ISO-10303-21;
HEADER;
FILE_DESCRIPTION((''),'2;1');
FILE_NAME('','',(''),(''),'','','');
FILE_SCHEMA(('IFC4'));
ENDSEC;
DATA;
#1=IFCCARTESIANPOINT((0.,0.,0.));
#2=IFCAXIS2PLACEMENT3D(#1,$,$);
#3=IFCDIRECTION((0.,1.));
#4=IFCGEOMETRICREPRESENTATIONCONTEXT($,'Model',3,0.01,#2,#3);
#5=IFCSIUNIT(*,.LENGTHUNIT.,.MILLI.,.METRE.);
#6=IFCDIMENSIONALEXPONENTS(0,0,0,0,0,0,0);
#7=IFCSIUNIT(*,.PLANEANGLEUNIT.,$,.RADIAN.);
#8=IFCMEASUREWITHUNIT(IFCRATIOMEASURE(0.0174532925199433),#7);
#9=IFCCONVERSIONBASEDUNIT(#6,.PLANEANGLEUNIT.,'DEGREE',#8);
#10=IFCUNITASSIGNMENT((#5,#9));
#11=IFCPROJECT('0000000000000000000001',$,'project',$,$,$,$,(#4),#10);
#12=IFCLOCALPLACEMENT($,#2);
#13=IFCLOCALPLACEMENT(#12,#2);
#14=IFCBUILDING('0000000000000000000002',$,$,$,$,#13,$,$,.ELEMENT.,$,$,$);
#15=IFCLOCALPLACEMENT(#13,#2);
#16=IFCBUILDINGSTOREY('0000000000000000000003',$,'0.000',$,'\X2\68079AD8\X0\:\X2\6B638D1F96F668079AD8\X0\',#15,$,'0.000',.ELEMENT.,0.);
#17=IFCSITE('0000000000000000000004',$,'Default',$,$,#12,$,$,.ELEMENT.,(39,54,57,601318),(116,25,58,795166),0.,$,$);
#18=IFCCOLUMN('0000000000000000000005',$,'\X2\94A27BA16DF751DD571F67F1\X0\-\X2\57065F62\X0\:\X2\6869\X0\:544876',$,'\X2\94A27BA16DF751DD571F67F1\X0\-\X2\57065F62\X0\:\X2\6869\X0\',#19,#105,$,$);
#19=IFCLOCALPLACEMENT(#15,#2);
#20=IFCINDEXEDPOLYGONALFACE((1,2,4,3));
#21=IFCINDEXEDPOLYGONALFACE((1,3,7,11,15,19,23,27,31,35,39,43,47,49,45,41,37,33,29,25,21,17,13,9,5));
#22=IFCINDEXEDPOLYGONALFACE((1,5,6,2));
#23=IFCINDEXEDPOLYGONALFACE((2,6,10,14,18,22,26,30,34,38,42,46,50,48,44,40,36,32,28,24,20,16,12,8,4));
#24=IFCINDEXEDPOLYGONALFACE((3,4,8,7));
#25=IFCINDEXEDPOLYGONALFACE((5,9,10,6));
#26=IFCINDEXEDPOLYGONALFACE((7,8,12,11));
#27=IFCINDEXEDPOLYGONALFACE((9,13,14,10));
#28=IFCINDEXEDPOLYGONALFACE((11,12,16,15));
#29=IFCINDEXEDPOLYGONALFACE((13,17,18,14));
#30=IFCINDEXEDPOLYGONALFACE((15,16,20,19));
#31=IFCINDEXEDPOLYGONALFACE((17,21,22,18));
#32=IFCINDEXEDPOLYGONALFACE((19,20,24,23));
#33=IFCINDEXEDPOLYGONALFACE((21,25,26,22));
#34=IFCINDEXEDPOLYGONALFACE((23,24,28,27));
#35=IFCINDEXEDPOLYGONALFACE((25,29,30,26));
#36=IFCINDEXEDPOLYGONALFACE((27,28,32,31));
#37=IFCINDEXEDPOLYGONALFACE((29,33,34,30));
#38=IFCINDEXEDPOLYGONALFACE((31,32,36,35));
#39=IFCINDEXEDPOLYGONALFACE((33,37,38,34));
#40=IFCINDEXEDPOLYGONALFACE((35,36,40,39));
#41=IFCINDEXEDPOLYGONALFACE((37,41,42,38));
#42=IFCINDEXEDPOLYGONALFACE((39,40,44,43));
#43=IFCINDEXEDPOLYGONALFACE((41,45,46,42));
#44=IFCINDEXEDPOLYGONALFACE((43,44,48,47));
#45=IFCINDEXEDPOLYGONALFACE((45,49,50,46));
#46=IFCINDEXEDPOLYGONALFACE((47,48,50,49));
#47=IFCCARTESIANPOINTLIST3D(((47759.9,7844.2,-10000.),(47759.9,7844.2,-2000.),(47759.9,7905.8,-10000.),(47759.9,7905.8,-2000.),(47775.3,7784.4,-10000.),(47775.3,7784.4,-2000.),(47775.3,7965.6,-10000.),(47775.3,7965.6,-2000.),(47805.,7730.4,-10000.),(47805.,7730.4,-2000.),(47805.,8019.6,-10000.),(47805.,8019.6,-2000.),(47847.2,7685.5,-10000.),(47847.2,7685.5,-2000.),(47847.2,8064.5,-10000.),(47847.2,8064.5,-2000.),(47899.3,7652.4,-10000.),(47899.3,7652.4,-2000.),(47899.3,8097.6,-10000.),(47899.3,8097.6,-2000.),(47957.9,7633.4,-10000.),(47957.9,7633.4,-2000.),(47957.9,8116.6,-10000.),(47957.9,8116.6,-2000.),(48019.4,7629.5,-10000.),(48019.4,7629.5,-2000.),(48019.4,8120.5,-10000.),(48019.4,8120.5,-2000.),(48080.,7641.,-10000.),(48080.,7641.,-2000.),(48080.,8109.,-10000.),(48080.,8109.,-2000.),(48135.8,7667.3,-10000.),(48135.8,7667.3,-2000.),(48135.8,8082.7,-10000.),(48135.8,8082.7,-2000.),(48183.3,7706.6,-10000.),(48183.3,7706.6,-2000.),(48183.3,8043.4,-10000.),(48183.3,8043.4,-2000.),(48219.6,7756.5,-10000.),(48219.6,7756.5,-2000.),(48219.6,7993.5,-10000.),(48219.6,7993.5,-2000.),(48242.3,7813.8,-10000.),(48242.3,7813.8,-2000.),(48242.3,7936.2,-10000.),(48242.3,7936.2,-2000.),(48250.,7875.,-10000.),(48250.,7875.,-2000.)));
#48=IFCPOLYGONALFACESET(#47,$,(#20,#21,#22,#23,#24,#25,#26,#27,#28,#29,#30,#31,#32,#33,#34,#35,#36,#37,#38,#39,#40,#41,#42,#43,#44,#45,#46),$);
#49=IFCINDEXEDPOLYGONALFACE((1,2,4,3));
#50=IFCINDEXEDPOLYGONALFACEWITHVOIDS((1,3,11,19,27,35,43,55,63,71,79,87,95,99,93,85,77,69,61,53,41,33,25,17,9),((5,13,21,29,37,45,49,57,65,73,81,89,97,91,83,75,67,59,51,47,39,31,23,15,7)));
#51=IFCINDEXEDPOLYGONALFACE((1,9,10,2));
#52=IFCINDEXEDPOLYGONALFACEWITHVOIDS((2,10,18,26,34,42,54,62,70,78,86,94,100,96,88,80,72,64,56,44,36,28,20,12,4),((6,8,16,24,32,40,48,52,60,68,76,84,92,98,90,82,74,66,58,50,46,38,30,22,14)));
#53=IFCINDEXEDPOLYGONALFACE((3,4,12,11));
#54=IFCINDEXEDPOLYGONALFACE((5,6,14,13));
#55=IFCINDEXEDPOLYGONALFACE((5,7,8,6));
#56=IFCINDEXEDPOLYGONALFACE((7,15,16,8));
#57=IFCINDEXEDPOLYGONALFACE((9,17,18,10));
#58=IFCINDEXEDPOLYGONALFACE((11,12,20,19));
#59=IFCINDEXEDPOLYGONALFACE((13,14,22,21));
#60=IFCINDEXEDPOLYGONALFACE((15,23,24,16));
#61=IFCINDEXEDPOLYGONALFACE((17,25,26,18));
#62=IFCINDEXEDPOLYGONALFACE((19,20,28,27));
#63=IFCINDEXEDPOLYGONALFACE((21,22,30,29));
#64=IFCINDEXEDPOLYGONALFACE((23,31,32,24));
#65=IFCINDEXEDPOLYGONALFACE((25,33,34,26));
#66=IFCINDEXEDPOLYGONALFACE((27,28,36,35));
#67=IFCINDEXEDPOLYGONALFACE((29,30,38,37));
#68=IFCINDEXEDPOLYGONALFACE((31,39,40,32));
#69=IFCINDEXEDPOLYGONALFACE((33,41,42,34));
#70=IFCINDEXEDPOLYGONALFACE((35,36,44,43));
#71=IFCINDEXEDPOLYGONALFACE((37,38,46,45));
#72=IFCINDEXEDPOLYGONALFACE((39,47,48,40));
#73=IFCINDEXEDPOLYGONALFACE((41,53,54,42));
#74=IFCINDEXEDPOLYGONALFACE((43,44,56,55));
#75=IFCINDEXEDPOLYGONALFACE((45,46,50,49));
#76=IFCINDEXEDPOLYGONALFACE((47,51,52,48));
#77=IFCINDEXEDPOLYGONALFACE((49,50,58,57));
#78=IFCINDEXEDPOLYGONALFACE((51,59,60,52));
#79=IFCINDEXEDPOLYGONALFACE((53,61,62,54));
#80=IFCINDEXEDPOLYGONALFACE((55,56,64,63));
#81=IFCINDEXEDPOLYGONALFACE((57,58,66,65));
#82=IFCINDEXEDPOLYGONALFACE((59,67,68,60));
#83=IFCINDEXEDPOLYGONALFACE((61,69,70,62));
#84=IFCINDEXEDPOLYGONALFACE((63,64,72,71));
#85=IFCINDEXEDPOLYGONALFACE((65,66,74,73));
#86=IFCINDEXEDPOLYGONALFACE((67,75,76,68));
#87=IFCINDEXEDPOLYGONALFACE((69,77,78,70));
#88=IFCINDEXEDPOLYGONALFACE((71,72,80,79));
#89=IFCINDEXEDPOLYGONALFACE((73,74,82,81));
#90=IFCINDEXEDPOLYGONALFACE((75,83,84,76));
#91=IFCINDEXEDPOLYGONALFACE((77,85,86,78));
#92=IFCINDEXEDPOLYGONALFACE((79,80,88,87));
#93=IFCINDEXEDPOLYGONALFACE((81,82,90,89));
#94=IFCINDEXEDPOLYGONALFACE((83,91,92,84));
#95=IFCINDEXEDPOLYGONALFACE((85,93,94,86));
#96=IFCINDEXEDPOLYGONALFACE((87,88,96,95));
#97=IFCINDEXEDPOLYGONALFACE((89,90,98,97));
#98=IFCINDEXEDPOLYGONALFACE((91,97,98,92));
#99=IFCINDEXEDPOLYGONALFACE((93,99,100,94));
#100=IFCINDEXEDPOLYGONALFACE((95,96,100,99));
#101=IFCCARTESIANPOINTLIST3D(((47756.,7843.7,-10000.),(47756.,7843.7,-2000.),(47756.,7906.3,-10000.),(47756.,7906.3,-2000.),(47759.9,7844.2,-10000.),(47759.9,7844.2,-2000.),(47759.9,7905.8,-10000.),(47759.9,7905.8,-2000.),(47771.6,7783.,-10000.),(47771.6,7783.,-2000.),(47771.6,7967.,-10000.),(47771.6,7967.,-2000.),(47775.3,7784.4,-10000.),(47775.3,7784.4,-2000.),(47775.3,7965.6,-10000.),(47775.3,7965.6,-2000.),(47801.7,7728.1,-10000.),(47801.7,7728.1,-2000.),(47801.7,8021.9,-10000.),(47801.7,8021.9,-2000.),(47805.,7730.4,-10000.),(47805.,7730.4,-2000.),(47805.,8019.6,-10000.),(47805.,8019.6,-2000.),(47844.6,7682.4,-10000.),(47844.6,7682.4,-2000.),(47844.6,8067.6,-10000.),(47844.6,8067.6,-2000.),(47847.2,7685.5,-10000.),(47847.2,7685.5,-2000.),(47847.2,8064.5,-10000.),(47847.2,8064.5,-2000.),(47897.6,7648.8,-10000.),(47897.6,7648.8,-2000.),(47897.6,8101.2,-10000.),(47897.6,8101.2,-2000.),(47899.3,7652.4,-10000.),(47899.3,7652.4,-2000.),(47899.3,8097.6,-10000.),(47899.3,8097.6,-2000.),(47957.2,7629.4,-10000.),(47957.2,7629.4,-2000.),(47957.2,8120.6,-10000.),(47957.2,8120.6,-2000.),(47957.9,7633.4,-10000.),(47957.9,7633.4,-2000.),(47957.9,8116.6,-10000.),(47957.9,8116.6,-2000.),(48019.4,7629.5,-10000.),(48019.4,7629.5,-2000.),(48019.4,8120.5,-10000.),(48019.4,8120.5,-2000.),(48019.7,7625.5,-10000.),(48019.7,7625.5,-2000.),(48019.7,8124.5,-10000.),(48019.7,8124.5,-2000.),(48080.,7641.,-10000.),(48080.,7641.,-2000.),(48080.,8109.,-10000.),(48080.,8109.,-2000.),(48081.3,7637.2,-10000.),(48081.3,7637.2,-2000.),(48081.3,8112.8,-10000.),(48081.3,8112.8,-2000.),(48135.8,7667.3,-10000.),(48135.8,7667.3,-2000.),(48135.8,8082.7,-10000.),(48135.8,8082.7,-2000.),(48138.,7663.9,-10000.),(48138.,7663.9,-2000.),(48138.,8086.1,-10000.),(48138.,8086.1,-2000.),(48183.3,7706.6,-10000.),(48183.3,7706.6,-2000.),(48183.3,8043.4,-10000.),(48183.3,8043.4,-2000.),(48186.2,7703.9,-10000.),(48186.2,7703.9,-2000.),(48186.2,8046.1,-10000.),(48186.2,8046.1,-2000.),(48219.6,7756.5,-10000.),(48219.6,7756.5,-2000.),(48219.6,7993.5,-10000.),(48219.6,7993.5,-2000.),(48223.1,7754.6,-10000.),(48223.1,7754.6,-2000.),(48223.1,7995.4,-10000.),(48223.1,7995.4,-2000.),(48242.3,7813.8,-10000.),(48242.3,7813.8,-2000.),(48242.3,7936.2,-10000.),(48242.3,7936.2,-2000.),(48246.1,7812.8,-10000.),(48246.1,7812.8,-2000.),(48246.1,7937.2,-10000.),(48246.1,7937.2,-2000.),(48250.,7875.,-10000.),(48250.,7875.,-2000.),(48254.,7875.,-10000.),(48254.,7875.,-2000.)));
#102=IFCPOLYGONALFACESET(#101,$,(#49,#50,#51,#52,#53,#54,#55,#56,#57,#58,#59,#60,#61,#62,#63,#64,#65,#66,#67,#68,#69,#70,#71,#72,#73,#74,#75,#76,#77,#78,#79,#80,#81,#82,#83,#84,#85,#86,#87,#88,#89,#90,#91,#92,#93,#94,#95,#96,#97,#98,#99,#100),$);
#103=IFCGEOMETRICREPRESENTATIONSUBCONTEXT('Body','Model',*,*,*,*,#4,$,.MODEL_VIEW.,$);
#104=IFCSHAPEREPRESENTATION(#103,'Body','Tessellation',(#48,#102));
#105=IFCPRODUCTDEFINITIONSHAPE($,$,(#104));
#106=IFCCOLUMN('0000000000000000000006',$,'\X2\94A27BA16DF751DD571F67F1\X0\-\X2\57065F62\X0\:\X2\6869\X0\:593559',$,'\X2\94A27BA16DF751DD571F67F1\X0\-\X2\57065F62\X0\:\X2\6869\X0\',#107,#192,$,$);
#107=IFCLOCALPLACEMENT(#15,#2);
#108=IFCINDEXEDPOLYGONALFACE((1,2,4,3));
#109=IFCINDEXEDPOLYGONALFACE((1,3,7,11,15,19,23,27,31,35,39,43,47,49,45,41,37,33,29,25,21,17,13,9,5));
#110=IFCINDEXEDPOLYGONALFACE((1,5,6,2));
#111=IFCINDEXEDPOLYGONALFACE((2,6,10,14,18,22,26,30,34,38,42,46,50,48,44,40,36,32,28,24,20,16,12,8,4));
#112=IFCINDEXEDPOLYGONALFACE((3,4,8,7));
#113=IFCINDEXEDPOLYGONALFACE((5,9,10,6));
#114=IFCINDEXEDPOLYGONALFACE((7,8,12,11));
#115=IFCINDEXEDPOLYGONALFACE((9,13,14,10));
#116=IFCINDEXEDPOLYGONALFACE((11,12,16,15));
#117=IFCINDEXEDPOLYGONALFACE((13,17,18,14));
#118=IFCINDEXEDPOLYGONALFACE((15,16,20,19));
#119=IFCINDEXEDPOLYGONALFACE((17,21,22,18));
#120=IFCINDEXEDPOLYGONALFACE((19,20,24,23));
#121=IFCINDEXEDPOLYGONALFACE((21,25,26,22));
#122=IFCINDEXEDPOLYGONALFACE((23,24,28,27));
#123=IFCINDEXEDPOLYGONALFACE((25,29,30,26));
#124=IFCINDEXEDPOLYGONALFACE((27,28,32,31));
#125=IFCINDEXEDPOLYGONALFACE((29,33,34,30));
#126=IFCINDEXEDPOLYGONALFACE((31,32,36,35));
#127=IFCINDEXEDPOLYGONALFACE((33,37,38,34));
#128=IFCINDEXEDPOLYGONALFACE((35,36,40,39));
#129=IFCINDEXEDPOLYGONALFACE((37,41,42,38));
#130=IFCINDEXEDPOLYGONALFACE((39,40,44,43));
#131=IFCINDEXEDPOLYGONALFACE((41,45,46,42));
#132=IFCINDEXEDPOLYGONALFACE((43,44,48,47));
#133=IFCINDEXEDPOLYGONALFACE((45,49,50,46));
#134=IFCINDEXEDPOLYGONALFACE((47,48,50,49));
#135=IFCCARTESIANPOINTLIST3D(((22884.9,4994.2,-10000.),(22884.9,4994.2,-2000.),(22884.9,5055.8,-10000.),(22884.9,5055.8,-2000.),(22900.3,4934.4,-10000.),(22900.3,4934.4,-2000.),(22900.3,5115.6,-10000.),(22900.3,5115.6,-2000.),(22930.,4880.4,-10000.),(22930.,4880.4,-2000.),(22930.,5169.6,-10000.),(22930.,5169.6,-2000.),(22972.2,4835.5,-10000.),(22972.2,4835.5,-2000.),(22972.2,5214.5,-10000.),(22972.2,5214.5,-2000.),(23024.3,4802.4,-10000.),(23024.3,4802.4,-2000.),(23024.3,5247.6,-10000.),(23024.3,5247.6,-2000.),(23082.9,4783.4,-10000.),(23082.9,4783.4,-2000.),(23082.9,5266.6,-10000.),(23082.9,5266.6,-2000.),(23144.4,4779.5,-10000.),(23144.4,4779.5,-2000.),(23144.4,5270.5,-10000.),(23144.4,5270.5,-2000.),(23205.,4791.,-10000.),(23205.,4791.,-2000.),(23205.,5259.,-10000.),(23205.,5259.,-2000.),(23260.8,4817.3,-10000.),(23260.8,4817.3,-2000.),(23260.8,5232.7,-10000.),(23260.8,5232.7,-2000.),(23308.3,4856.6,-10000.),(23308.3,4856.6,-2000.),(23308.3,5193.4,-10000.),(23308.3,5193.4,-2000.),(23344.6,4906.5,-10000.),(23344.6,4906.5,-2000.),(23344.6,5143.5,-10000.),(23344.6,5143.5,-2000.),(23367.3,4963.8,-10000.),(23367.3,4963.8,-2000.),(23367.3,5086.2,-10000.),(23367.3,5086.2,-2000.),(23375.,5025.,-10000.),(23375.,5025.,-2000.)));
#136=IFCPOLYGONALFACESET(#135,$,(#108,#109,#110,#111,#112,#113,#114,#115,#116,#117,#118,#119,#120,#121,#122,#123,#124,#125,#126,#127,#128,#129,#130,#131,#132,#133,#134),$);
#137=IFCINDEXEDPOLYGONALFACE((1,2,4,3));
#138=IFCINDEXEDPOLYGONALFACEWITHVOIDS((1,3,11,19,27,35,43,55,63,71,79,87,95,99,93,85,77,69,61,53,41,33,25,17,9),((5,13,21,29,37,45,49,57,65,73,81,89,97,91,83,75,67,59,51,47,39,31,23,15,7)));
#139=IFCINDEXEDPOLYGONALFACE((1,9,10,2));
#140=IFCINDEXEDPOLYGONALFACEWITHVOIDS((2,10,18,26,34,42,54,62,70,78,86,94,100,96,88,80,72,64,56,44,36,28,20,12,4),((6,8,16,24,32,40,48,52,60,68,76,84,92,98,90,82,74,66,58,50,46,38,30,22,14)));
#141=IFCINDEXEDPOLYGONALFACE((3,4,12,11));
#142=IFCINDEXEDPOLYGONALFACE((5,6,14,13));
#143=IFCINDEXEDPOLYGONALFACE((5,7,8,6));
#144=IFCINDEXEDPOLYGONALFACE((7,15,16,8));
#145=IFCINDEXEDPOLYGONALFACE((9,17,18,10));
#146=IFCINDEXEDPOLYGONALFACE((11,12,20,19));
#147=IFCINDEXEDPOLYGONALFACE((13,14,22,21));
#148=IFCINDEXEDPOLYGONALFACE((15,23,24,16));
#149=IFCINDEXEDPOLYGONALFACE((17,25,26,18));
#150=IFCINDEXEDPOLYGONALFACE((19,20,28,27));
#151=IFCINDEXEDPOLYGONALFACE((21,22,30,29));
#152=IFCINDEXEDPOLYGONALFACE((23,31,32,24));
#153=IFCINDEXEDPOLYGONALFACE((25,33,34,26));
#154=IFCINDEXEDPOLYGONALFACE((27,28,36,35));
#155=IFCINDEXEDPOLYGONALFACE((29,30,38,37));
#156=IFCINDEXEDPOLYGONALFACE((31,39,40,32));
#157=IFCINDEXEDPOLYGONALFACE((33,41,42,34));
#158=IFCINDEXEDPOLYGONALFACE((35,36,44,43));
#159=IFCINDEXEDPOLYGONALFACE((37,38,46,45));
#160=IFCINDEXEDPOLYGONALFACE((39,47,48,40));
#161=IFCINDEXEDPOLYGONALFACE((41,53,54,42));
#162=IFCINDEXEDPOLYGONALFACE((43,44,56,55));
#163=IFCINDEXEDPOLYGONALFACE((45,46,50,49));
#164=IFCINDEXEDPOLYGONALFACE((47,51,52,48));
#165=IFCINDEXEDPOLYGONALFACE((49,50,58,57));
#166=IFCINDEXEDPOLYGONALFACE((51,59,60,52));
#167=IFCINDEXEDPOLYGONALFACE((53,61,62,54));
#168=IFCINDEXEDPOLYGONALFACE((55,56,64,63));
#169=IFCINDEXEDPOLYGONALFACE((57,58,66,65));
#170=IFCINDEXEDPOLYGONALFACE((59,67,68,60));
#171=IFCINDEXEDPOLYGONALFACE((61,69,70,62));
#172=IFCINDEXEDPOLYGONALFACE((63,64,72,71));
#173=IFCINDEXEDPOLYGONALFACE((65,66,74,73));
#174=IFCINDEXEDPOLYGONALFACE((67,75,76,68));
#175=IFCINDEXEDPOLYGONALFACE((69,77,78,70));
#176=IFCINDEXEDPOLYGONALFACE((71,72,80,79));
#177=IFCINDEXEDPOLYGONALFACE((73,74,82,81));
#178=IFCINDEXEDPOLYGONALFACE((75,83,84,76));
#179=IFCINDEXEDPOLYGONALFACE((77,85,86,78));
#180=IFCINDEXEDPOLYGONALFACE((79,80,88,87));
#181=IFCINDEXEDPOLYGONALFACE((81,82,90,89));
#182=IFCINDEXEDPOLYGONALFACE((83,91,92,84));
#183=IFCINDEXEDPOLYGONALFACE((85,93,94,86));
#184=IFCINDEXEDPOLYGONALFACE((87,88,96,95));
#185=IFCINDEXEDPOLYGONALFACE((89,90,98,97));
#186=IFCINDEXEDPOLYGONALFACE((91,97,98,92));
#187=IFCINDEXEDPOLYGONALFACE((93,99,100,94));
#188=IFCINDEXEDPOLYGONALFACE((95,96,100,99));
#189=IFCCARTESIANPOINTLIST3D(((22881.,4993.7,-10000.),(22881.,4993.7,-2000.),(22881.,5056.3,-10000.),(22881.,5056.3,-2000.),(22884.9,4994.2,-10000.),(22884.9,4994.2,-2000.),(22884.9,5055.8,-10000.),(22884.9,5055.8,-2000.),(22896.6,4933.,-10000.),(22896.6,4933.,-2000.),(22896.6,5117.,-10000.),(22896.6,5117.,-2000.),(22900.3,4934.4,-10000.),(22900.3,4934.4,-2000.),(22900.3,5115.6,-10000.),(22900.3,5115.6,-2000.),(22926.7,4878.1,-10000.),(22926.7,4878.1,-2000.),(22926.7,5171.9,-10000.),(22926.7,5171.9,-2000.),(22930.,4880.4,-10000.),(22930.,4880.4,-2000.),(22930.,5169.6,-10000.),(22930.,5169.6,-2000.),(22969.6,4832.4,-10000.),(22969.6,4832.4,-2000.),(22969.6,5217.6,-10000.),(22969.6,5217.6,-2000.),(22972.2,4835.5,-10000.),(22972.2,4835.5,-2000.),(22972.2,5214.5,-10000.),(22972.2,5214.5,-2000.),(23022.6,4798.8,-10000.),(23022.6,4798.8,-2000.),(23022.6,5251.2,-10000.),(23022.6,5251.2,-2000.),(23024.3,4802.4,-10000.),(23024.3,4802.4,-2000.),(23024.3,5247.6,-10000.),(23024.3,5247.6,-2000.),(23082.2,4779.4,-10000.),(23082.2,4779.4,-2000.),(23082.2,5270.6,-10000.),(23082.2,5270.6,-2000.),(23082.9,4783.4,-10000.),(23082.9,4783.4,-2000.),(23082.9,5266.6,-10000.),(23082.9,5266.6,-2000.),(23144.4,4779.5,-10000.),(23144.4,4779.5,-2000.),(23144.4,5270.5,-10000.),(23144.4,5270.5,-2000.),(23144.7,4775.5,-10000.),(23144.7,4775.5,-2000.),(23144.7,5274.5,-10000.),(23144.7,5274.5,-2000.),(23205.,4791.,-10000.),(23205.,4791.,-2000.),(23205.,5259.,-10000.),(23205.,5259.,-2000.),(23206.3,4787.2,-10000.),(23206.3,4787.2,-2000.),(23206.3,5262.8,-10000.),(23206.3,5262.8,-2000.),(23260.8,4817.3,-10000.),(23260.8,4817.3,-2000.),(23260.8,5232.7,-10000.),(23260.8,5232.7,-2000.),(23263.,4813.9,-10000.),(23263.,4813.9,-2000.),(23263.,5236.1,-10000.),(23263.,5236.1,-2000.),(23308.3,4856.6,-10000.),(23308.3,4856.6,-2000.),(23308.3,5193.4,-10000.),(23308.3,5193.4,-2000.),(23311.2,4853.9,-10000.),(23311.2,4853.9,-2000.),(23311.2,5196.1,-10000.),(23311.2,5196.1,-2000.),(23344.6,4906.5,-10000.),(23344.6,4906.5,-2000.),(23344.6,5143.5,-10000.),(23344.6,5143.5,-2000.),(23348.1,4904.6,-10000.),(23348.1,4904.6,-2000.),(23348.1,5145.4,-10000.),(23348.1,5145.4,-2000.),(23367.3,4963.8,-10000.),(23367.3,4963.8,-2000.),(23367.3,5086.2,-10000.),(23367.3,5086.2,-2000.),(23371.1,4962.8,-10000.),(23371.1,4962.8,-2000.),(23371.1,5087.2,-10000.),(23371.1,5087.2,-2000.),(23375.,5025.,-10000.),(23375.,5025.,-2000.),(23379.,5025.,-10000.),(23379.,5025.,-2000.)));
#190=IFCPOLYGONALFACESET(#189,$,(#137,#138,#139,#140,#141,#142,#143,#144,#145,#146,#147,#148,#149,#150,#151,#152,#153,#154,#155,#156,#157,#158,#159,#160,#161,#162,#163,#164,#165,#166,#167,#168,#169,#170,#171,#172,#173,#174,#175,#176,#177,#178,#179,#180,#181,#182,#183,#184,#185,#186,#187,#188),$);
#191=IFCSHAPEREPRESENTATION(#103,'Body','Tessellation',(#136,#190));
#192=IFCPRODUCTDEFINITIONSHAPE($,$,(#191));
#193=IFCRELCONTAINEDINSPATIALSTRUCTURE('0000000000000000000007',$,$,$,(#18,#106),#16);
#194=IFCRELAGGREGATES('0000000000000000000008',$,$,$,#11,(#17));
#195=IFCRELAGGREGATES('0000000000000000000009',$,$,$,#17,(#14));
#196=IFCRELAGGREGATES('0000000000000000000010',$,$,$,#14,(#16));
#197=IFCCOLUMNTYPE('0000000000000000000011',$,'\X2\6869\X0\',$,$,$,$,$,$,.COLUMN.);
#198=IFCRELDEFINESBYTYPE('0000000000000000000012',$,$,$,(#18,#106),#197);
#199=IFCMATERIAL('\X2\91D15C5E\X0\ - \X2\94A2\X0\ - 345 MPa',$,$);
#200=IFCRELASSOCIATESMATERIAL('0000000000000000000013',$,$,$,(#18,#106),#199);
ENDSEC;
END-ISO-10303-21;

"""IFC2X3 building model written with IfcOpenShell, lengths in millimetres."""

from ifc_helpers import new_model, entity, si_unit, converted_unit, direction, frame, frame_2d, origin, place, context, subcontext, project, spatial, circle, hollow_circle, extrude, source, transform, mapped, material, type_object, type_shapes, element, save


model = new_model("IFC2X3")

# Units and contexts
model_context = context("Model", 3, precision=0.01, world=origin(), true_north=direction((0.0, 1.0)))
body_context = subcontext(model_context, "Body", "Model", "MODEL_VIEW")
ifc_project = project(units=[si_unit("LENGTHUNIT", "METRE", prefix="MILLI"), converted_unit("PLANEANGLEUNIT", "DEGREE", entity("IfcRatioMeasure", 0.0174532925199433), si_unit("PLANEANGLEUNIT", "RADIAN"), dimensions=[0, 0, 0, 0, 0, 0, 0])], contexts=[model_context])

# Site, building, storey
site_placement = place(None, origin())
site = spatial("IfcSite", under=ifc_project, at=site_placement, Name="Default", CompositionType="ELEMENT", RefLatitude=(39, 54, 57, 601318), RefLongitude=(116, 25, 58, 795166), RefElevation=0.0)
building_placement = place(site_placement, origin())
building = spatial("IfcBuilding", under=site, at=building_placement, CompositionType="ELEMENT")
storey_placement = place(building_placement, origin())
storey = spatial("IfcBuildingStorey", under=building, at=storey_placement, Name="0.000", ObjectType="标高:正负零标高", LongName="0.000", CompositionType="ELEMENT", Elevation=0.0)

# Columns
ifc_material_1 = material(Name="金属 - 钢 - 345 MPa")
column_type = type_object("IfcColumnType", Name="桩", PredefinedType="COLUMN")
shared_shape = source(origin(), body_context, "Body", "SweptSolid", [
    extrude(circle(Radius=246.0, at=frame_2d((0.0, 0.0), x_axis=(1.0, 0.0))), frame((0.0, 0.0, -10000.0)), (0.0, 0.0, 1.0), 8000.0),
    extrude(hollow_circle(Radius=250.0, WallThickness=4.0, at=frame_2d((0.0, 0.0), x_axis=(1.0, 0.0))), frame((0.0, 0.0, -10000.0)), (0.0, 0.0, 1.0), 8000.0),
])
type_shapes(column_type, [shared_shape])
for number, where, name in (
    (1, (48004.0, 7875.0, 0.0), "钢管混凝土柱-圆形:桩:544876"),
    (2, (23129.0, 5025.0, 0.0), "钢管混凝土柱-圆形:桩:593559"),
):
    element("IfcColumn", number, at=place(storey_placement, frame(where)), inside=storey, type_object=column_type, material=ifc_material_1, Name=name, ObjectType="钢管混凝土柱-圆形:桩", context=body_context, shape_type="MappedRepresentation", body=[
        mapped(shared_shape, transform((0.0, 0.0, 0.0), scale=1.0)),
    ])

save(model, "model.ifc")
